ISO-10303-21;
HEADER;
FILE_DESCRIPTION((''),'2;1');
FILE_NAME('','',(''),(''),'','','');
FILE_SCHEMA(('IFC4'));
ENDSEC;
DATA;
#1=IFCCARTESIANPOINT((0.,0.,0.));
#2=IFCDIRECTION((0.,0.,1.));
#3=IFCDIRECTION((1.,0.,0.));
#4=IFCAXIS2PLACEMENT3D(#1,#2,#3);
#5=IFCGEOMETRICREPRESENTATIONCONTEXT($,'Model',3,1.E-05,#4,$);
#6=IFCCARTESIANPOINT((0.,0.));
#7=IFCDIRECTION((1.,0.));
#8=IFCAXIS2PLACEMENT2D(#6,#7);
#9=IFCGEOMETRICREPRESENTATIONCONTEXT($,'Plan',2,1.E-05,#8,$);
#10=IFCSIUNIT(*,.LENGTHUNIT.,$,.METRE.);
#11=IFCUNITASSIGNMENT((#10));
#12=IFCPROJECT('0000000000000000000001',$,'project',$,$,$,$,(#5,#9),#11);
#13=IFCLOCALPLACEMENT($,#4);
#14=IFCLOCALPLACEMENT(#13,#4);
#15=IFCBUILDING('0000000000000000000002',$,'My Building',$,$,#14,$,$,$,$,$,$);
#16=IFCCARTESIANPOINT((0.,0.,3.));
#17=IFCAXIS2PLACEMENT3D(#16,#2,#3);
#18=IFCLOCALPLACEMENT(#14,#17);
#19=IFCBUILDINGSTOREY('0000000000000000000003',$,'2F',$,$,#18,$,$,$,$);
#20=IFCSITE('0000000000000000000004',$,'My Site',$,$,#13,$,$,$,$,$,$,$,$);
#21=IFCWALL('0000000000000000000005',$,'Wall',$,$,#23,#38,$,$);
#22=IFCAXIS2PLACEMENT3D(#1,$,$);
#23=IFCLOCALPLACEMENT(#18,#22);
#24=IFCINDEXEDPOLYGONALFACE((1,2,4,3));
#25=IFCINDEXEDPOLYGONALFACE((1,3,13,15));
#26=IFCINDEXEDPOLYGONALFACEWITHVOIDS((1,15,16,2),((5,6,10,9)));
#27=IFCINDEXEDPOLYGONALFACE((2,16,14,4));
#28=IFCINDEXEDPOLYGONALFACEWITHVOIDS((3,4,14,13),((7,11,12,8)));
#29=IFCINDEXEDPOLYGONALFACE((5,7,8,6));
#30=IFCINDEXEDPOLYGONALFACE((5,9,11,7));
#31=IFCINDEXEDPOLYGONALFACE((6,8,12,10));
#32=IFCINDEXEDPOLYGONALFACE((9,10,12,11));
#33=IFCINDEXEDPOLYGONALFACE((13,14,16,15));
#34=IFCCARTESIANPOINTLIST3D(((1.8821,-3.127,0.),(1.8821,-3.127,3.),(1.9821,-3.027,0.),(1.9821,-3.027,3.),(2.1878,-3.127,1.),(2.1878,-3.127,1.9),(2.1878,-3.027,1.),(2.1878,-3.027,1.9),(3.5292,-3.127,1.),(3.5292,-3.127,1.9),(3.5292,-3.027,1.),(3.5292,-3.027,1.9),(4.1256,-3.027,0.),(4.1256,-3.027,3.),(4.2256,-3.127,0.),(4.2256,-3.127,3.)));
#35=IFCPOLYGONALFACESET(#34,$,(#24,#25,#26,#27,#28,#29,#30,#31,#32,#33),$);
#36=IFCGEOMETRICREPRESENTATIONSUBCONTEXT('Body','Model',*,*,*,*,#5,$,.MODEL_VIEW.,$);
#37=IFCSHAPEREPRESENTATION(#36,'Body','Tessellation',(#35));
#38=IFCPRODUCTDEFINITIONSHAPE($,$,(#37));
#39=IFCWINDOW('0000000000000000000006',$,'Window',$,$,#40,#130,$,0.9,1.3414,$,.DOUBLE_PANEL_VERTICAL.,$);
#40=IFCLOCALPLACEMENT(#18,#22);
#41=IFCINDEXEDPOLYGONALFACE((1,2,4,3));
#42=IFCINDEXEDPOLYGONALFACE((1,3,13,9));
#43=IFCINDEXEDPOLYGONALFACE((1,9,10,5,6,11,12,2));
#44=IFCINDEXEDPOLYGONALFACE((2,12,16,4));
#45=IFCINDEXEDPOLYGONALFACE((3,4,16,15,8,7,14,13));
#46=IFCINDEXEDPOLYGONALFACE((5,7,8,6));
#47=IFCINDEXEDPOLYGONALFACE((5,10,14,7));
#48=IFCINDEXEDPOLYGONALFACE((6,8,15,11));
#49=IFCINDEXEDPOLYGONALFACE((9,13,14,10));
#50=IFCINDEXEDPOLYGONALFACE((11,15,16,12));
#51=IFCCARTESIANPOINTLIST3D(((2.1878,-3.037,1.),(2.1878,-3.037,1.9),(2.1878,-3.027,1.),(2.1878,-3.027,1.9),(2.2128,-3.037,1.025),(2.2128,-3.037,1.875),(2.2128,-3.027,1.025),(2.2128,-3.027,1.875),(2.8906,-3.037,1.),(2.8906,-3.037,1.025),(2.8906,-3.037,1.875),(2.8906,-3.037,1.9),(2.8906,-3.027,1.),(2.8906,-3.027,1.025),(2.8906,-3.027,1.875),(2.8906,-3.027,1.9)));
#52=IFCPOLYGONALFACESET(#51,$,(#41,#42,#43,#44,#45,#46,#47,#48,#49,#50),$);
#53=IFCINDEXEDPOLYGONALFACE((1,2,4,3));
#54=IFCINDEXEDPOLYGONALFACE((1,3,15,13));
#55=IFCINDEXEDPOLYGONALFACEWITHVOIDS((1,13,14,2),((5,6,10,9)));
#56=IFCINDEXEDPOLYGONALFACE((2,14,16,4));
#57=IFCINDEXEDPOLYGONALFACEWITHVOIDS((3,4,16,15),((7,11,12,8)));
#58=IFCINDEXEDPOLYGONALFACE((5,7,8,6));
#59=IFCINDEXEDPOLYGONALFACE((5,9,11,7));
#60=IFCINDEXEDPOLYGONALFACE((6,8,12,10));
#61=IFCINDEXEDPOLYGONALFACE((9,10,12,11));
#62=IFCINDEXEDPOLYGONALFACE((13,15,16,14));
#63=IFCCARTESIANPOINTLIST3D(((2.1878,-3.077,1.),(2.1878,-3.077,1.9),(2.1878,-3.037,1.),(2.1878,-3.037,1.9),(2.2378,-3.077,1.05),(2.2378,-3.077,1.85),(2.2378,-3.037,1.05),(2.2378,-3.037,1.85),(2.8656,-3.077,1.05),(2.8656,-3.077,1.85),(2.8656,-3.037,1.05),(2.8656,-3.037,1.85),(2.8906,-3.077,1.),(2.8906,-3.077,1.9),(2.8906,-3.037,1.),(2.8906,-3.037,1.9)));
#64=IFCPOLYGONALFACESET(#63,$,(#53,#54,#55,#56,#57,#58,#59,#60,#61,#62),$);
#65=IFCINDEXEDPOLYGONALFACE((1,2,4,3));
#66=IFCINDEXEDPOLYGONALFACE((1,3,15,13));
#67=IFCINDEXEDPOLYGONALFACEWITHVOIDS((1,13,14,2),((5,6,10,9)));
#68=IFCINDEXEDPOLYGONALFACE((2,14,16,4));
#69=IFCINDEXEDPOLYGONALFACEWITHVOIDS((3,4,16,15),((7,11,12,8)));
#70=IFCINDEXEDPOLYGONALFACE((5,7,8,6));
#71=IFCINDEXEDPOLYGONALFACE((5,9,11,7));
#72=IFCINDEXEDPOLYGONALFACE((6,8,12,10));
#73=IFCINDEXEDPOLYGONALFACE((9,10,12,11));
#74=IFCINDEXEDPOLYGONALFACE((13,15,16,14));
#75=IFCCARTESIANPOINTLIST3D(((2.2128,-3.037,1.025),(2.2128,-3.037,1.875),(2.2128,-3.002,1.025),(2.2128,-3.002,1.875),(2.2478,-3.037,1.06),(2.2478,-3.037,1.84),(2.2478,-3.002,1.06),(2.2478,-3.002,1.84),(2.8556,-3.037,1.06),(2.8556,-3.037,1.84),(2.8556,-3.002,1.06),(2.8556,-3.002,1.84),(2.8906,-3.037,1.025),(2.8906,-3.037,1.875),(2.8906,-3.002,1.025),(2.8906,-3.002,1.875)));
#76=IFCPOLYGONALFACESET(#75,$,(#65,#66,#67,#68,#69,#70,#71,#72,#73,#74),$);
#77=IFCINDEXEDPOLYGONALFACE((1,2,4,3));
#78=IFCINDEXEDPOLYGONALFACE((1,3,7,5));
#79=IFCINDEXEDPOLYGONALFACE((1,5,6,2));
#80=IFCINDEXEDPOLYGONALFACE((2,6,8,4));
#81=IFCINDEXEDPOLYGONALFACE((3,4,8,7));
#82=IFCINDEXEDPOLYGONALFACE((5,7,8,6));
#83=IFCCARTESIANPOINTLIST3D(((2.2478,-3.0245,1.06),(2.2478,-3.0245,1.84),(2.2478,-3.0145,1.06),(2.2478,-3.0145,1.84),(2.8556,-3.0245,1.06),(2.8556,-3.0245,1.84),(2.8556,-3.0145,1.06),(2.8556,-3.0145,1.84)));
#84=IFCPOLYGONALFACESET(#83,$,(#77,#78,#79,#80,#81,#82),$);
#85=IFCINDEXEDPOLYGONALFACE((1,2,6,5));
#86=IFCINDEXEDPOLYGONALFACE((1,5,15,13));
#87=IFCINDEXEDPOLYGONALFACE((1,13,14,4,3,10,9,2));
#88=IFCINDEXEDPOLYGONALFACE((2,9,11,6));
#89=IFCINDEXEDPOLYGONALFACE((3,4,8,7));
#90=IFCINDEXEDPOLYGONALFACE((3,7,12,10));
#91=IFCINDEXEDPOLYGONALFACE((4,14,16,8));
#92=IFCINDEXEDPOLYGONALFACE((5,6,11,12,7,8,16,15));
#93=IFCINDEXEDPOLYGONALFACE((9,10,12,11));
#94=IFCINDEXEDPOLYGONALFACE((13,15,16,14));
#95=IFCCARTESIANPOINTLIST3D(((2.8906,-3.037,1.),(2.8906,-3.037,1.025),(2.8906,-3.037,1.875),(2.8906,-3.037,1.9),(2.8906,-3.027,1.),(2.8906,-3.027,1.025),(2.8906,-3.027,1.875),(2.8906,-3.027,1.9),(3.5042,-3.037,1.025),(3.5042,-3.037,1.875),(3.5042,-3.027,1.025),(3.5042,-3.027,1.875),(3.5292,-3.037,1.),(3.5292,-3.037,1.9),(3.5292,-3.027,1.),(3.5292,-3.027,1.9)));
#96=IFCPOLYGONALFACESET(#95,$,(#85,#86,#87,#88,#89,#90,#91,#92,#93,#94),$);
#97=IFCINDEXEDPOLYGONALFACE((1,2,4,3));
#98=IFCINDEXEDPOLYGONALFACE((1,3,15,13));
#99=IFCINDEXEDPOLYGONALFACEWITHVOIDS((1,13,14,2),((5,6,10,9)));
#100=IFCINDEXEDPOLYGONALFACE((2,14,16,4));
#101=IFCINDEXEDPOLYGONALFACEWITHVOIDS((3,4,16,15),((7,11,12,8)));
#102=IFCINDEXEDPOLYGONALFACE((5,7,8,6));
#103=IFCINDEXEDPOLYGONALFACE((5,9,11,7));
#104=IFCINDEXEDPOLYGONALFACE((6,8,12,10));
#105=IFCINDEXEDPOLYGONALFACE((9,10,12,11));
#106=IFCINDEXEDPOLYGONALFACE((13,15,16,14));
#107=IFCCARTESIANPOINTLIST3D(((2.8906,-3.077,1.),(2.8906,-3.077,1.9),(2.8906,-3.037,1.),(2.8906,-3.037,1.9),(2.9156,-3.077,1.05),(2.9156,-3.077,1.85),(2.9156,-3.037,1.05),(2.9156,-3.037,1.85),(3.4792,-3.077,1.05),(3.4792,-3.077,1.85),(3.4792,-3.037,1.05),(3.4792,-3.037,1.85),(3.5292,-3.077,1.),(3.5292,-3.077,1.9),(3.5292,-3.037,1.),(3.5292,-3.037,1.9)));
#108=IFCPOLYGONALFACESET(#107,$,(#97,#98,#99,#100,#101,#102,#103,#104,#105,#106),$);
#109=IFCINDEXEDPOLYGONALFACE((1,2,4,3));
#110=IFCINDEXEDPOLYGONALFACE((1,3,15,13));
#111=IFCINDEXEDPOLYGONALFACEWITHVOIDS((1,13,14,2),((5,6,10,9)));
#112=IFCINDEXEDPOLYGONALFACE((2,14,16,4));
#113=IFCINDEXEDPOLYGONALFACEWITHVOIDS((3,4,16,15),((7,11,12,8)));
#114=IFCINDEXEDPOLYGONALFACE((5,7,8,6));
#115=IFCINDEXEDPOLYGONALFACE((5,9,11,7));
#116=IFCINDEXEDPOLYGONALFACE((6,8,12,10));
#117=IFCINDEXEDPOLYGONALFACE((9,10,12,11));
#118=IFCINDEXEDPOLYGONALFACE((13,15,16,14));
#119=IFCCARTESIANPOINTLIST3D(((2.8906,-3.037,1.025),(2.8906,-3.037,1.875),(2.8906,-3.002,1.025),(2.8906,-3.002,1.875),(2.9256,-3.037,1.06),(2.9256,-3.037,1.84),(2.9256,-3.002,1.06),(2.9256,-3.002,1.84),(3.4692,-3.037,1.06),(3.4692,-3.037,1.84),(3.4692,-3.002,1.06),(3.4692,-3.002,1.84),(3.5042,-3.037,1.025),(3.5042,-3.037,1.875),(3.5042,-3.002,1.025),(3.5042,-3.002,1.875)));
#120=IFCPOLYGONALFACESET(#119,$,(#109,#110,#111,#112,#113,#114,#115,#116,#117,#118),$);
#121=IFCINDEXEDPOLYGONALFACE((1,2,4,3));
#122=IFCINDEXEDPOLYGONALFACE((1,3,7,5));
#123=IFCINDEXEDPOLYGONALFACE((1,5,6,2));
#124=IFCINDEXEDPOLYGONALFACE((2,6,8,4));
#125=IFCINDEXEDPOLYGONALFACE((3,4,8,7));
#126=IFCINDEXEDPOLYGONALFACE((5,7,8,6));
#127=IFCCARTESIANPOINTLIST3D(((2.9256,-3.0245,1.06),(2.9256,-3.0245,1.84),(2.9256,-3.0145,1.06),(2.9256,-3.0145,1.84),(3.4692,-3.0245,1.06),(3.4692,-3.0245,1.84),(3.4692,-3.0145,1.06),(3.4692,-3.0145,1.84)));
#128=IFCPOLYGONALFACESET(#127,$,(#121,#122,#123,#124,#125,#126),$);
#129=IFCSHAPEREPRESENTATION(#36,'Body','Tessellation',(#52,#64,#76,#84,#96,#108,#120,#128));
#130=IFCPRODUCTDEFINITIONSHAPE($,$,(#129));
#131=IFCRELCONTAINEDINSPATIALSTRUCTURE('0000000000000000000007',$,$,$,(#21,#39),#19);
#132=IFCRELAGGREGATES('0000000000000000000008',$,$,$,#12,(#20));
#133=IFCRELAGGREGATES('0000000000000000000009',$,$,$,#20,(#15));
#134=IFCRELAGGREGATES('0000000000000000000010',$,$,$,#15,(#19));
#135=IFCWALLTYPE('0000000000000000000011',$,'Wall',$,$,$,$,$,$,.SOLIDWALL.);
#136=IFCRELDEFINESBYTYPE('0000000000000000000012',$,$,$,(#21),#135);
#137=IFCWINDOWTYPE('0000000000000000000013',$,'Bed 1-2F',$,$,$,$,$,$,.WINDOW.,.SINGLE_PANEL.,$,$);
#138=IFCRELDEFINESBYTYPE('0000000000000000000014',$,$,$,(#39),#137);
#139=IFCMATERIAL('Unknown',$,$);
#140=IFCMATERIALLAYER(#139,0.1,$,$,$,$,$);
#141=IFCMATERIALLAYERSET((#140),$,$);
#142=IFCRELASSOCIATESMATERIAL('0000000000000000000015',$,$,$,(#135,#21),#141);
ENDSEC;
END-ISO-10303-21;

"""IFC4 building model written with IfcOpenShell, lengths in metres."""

from ifc_helpers import new_model, entity, si_unit, frame, origin_with_axes, origin_2d_with_axis, place, context, subcontext, project, spatial, line, indexed_curve, outline, extrude, shape, source, transform, mapped, material, layer, layer_set, layer_usage, type_object, type_shapes, element, fill, save


model = new_model("IFC4")

# Units and contexts
model_context = context("Model", 3, precision=1e-05, world=origin_with_axes())
plan_context = context("Plan", 2, precision=1e-05, world=origin_2d_with_axis())
body_context_1 = subcontext(model_context, "Body", "Model", "MODEL_VIEW")
body_context_2 = subcontext(plan_context, "Body", "Plan", "PLAN_VIEW")
ifc_project = project(units=[si_unit("LENGTHUNIT", "METRE")], contexts=[model_context, plan_context])

# Site, building, storey
site_placement = place(None, origin_with_axes())
site = spatial("IfcSite", under=ifc_project, at=site_placement, Name="My Site")
building_placement = place(site_placement, origin_with_axes())
building = spatial("IfcBuilding", under=site, at=building_placement, Name="My Building")
storey_placement = place(building_placement, frame((0.0, 0.0, 3.0), z_axis=(0.0, 0.0, 1.0), x_axis=(1.0, 0.0, 0.0)))
storey = spatial("IfcBuildingStorey", under=building, at=storey_placement, Name="2F")

# Shared definitions
ifc_material = material(Name="Unknown")

# Shared definitions
ifc_layer_1 = layer(ifc_material, 0.1)
ifc_layer_set_1 = layer_set([ifc_layer_1])
wall_type = type_object("IfcWallType", Name="Wall", PredefinedType="SOLIDWALL", material=ifc_layer_set_1)

# Wall, opening, window
ifc_layer_usage_1 = layer_usage(ifc_layer_set_1, "AXIS2", "POSITIVE", 0.0)
wall_1_placement = place(storey_placement, frame((1.8821, -3.127, 0.0), z_axis=(0.0, 0.0, 1.0), x_axis=(1.0, 0.0, 0.0)))
wall_1 = element("IfcWall", 1, at=wall_1_placement, inside=storey, type_object=wall_type, material=ifc_layer_usage_1, Name="Wall", context=body_context_1, shape_type="SweptSolid", body=[
    extrude(outline(indexed_curve([(0.0, 0.0), (0.1, 0.1), (2.2435, 0.1), (2.3435, 0.0)], segments=[line(1, 2, 3, 4, 1)])), origin_with_axes(), (0.0, 0.0, 1.0), 3.0),
])
shared_shape_1 = source(origin_with_axes(), body_context_1, "Body", "SweptSolid", [
    extrude(outline(indexed_curve([(0.0, 0.0), (1.3414, 0.0), (1.3414, 0.9), (0.0, 0.9)], segments=[line(1, 2, 3, 4, 1)])), frame((0.0, -0.6, 0.0), z_axis=(0.0, -1.0, 0.0), x_axis=(1.0, 0.0, 0.0)), (0.0, 0.0, -1.0), 1.2),
])
opening_1_placement = place(wall_1_placement, frame((0.3057, 0.0, 1.0), z_axis=(0.0, 0.0, 1.0), x_axis=(1.0, 0.0, 0.0)))
opening_1 = element("IfcOpeningElement", 2, at=opening_1_placement, cuts=wall_1, PredefinedType="OPENING", context=body_context_1, shape_type="MappedRepresentation", body=[
    mapped(shared_shape_1, transform((0.0, 0.0, 0.0), x_axis=(1.0, 0.0, 0.0), y_axis=(0.0, 1.0, 0.0), z_axis=(0.0, 0.0, 1.0), scale=1.0)),
])
window_type_1 = type_object("IfcWindowType", Name="Bed 1-2F", PartitioningType="SINGLE_PANEL", PredefinedType="WINDOW")
shared_shape_2 = source(origin_with_axes(), body_context_1, "Body", "SweptSolid", [
    extrude(outline(indexed_curve([(0.7028, 0.0), (0.0, 0.0), (0.0, 0.9), (0.7028, 0.9), (0.7028, 0.875), (0.025, 0.875), (0.025, 0.025), (0.7028, 0.025)], segments=[line(1, 2, 3, 4, 5, 6, 7, 8, 1)])), frame((0.0, 0.09, 0.0), z_axis=(0.0, -1.0, 0.0), x_axis=(1.0, 0.0, 0.0)), (0.0, 0.0, -1.0), 0.01),
    extrude(outline(indexed_curve([(0.0, 0.0), (0.7028, 0.0), (0.7028, 0.9), (0.0, 0.9)], segments=[line(1, 2, 3, 4, 1)]), holes=[indexed_curve([(0.05, 0.05), (0.6778, 0.05), (0.6778, 0.85), (0.05, 0.85)], segments=[line(1, 2, 3, 4, 1)])]), frame((0.0, 0.05, 0.0), z_axis=(0.0, -1.0, 0.0), x_axis=(1.0, 0.0, 0.0)), (0.0, 0.0, -1.0), 0.04),
    extrude(outline(indexed_curve([(0.0, 0.0), (0.6778, 0.0), (0.6778, 0.85), (0.0, 0.85)], segments=[line(1, 2, 3, 4, 1)]), holes=[indexed_curve([(0.035, 0.035), (0.6428, 0.035), (0.6428, 0.815), (0.035, 0.815)], segments=[line(1, 2, 3, 4, 1)])]), frame((0.025, 0.09, 0.025), z_axis=(0.0, -1.0, 0.0), x_axis=(1.0, 0.0, 0.0)), (0.0, 0.0, -1.0), 0.035),
    extrude(outline(indexed_curve([(0.035, 0.035), (0.6428, 0.035), (0.6428, 0.815), (0.035, 0.815)], segments=[line(1, 2, 3, 4, 1)])), frame((0.025, 0.1025, 0.025), z_axis=(0.0, -1.0, 0.0), x_axis=(1.0, 0.0, 0.0)), (0.0, 0.0, -1.0), 0.01),
    extrude(outline(indexed_curve([(0.0, 0.9), (0.6386, 0.9), (0.6386, 0.0), (0.0, 0.0), (0.0, 0.025), (0.6136, 0.025), (0.6136, 0.875), (0.0, 0.875)], segments=[line(1, 2, 3, 4, 5, 6, 7, 8, 1)])), frame((0.7028, 0.09, 0.0), z_axis=(0.0, -1.0, 0.0), x_axis=(1.0, 0.0, 0.0)), (0.0, 0.0, -1.0), 0.01),
    extrude(outline(indexed_curve([(0.0, 0.0), (0.6386, 0.0), (0.6386, 0.9), (0.0, 0.9)], segments=[line(1, 2, 3, 4, 1)]), holes=[indexed_curve([(0.025, 0.05), (0.5886, 0.05), (0.5886, 0.85), (0.025, 0.85)], segments=[line(1, 2, 3, 4, 1)])]), frame((0.7028, 0.05, 0.0), z_axis=(0.0, -1.0, 0.0), x_axis=(1.0, 0.0, 0.0)), (0.0, 0.0, -1.0), 0.04),
    extrude(outline(indexed_curve([(0.0, 0.0), (0.6136, 0.0), (0.6136, 0.85), (0.0, 0.85)], segments=[line(1, 2, 3, 4, 1)]), holes=[indexed_curve([(0.035, 0.035), (0.5786, 0.035), (0.5786, 0.815), (0.035, 0.815)], segments=[line(1, 2, 3, 4, 1)])]), frame((0.7028, 0.09, 0.025), z_axis=(0.0, -1.0, 0.0), x_axis=(1.0, 0.0, 0.0)), (0.0, 0.0, -1.0), 0.035),
    extrude(outline(indexed_curve([(0.035, 0.035), (0.5786, 0.035), (0.5786, 0.815), (0.035, 0.815)], segments=[line(1, 2, 3, 4, 1)])), frame((0.7028, 0.1025, 0.025), z_axis=(0.0, -1.0, 0.0), x_axis=(1.0, 0.0, 0.0)), (0.0, 0.0, -1.0), 0.01),
])
shared_shape_3 = source(origin_with_axes(), body_context_2, "Body", "Curve2D", [
    entity("IfcIndexedPolyCurve", entity("IfcCartesianPointList2D", [[0.05, 0.05], [0.6778, 0.05]])),
    entity("IfcIndexedPolyCurve", entity("IfcCartesianPointList2D", [[0.0, 0.1], [0.025, 0.1], [0.025, 0.09], [0.05, 0.09], [0.05, 0.05], [0.0, 0.05]]), [entity("IfcLineIndex", [1, 2, 3, 4, 5, 6, 1])]),
    entity("IfcIndexedPolyCurve", entity("IfcCartesianPointList2D", [[0.7028, 0.1], [0.7028, 0.1], [0.7028, 0.09], [0.6778, 0.09], [0.6778, 0.05], [0.7028, 0.05]])),
    entity("IfcIndexedPolyCurve", entity("IfcCartesianPointList2D", [[0.025, 0.09], [0.06, 0.09], [0.06, 0.125], [0.025, 0.125]]), [entity("IfcLineIndex", [1, 2, 3, 4, 1])]),
    entity("IfcIndexedPolyCurve", entity("IfcCartesianPointList2D", [[0.7028, 0.09], [0.6678, 0.09], [0.6678, 0.125], [0.7028, 0.125]]), [entity("IfcLineIndex", [1, 2, 3, 4, 1])]),
    entity("IfcIndexedPolyCurve", entity("IfcCartesianPointList2D", [[0.06, 0.09], [0.6678, 0.09]])),
    entity("IfcIndexedPolyCurve", entity("IfcCartesianPointList2D", [[0.06, 0.125], [0.6678, 0.125]])),
    entity("IfcIndexedPolyCurve", entity("IfcCartesianPointList2D", [[0.06, 0.1075], [0.6678, 0.1075]])),
    entity("IfcIndexedPolyCurve", entity("IfcCartesianPointList2D", [[0.7278, 0.05], [1.2914, 0.05]])),
    entity("IfcIndexedPolyCurve", entity("IfcCartesianPointList2D", [[0.7028, 0.1], [0.7028, 0.1], [0.7028, 0.09], [0.7278, 0.09], [0.7278, 0.05], [0.7028, 0.05]])),
    entity("IfcIndexedPolyCurve", entity("IfcCartesianPointList2D", [[1.3414, 0.1], [1.3164, 0.1], [1.3164, 0.09], [1.2914, 0.09], [1.2914, 0.05], [1.3414, 0.05]]), [entity("IfcLineIndex", [1, 2, 3, 4, 5, 6, 1])]),
    entity("IfcIndexedPolyCurve", entity("IfcCartesianPointList2D", [[0.7028, 0.09], [0.7378, 0.09], [0.7378, 0.125], [0.7028, 0.125]]), [entity("IfcLineIndex", [1, 2, 3, 4, 1])]),
    entity("IfcIndexedPolyCurve", entity("IfcCartesianPointList2D", [[1.3164, 0.09], [1.2814, 0.09], [1.2814, 0.125], [1.3164, 0.125]]), [entity("IfcLineIndex", [1, 2, 3, 4, 1])]),
    entity("IfcIndexedPolyCurve", entity("IfcCartesianPointList2D", [[0.7378, 0.09], [1.2814, 0.09]])),
    entity("IfcIndexedPolyCurve", entity("IfcCartesianPointList2D", [[0.7378, 0.125], [1.2814, 0.125]])),
    entity("IfcIndexedPolyCurve", entity("IfcCartesianPointList2D", [[0.7378, 0.1075], [1.2814, 0.1075]])),
])
type_shapes(window_type_1, [shared_shape_2, shared_shape_3])
window_1_placement = place(opening_1_placement, origin_with_axes())
window_1 = element("IfcWindow", 3, at=window_1_placement, inside=storey, type_object=window_type_1, Name="Window", OverallHeight=0.9, OverallWidth=1.3414, PartitioningType="DOUBLE_PANEL_VERTICAL", shapes=[
    shape(body_context_1, "Body", "MappedRepresentation", [mapped(shared_shape_2, transform((0.0, 0.0, 0.0), x_axis=(1.0, 0.0, 0.0), y_axis=(0.0, 1.0, 0.0), z_axis=(0.0, 0.0, 1.0), scale=1.0))]),
    shape(body_context_2, "Body", "MappedRepresentation", [mapped(shared_shape_3, transform((0.0, 0.0, 0.0), x_axis=(1.0, 0.0, 0.0), y_axis=(0.0, 1.0, 0.0), z_axis=(0.0, 0.0, 1.0), scale=1.0))]),
])
fill(opening_1, window_1)

save(model, "model.ifc")
